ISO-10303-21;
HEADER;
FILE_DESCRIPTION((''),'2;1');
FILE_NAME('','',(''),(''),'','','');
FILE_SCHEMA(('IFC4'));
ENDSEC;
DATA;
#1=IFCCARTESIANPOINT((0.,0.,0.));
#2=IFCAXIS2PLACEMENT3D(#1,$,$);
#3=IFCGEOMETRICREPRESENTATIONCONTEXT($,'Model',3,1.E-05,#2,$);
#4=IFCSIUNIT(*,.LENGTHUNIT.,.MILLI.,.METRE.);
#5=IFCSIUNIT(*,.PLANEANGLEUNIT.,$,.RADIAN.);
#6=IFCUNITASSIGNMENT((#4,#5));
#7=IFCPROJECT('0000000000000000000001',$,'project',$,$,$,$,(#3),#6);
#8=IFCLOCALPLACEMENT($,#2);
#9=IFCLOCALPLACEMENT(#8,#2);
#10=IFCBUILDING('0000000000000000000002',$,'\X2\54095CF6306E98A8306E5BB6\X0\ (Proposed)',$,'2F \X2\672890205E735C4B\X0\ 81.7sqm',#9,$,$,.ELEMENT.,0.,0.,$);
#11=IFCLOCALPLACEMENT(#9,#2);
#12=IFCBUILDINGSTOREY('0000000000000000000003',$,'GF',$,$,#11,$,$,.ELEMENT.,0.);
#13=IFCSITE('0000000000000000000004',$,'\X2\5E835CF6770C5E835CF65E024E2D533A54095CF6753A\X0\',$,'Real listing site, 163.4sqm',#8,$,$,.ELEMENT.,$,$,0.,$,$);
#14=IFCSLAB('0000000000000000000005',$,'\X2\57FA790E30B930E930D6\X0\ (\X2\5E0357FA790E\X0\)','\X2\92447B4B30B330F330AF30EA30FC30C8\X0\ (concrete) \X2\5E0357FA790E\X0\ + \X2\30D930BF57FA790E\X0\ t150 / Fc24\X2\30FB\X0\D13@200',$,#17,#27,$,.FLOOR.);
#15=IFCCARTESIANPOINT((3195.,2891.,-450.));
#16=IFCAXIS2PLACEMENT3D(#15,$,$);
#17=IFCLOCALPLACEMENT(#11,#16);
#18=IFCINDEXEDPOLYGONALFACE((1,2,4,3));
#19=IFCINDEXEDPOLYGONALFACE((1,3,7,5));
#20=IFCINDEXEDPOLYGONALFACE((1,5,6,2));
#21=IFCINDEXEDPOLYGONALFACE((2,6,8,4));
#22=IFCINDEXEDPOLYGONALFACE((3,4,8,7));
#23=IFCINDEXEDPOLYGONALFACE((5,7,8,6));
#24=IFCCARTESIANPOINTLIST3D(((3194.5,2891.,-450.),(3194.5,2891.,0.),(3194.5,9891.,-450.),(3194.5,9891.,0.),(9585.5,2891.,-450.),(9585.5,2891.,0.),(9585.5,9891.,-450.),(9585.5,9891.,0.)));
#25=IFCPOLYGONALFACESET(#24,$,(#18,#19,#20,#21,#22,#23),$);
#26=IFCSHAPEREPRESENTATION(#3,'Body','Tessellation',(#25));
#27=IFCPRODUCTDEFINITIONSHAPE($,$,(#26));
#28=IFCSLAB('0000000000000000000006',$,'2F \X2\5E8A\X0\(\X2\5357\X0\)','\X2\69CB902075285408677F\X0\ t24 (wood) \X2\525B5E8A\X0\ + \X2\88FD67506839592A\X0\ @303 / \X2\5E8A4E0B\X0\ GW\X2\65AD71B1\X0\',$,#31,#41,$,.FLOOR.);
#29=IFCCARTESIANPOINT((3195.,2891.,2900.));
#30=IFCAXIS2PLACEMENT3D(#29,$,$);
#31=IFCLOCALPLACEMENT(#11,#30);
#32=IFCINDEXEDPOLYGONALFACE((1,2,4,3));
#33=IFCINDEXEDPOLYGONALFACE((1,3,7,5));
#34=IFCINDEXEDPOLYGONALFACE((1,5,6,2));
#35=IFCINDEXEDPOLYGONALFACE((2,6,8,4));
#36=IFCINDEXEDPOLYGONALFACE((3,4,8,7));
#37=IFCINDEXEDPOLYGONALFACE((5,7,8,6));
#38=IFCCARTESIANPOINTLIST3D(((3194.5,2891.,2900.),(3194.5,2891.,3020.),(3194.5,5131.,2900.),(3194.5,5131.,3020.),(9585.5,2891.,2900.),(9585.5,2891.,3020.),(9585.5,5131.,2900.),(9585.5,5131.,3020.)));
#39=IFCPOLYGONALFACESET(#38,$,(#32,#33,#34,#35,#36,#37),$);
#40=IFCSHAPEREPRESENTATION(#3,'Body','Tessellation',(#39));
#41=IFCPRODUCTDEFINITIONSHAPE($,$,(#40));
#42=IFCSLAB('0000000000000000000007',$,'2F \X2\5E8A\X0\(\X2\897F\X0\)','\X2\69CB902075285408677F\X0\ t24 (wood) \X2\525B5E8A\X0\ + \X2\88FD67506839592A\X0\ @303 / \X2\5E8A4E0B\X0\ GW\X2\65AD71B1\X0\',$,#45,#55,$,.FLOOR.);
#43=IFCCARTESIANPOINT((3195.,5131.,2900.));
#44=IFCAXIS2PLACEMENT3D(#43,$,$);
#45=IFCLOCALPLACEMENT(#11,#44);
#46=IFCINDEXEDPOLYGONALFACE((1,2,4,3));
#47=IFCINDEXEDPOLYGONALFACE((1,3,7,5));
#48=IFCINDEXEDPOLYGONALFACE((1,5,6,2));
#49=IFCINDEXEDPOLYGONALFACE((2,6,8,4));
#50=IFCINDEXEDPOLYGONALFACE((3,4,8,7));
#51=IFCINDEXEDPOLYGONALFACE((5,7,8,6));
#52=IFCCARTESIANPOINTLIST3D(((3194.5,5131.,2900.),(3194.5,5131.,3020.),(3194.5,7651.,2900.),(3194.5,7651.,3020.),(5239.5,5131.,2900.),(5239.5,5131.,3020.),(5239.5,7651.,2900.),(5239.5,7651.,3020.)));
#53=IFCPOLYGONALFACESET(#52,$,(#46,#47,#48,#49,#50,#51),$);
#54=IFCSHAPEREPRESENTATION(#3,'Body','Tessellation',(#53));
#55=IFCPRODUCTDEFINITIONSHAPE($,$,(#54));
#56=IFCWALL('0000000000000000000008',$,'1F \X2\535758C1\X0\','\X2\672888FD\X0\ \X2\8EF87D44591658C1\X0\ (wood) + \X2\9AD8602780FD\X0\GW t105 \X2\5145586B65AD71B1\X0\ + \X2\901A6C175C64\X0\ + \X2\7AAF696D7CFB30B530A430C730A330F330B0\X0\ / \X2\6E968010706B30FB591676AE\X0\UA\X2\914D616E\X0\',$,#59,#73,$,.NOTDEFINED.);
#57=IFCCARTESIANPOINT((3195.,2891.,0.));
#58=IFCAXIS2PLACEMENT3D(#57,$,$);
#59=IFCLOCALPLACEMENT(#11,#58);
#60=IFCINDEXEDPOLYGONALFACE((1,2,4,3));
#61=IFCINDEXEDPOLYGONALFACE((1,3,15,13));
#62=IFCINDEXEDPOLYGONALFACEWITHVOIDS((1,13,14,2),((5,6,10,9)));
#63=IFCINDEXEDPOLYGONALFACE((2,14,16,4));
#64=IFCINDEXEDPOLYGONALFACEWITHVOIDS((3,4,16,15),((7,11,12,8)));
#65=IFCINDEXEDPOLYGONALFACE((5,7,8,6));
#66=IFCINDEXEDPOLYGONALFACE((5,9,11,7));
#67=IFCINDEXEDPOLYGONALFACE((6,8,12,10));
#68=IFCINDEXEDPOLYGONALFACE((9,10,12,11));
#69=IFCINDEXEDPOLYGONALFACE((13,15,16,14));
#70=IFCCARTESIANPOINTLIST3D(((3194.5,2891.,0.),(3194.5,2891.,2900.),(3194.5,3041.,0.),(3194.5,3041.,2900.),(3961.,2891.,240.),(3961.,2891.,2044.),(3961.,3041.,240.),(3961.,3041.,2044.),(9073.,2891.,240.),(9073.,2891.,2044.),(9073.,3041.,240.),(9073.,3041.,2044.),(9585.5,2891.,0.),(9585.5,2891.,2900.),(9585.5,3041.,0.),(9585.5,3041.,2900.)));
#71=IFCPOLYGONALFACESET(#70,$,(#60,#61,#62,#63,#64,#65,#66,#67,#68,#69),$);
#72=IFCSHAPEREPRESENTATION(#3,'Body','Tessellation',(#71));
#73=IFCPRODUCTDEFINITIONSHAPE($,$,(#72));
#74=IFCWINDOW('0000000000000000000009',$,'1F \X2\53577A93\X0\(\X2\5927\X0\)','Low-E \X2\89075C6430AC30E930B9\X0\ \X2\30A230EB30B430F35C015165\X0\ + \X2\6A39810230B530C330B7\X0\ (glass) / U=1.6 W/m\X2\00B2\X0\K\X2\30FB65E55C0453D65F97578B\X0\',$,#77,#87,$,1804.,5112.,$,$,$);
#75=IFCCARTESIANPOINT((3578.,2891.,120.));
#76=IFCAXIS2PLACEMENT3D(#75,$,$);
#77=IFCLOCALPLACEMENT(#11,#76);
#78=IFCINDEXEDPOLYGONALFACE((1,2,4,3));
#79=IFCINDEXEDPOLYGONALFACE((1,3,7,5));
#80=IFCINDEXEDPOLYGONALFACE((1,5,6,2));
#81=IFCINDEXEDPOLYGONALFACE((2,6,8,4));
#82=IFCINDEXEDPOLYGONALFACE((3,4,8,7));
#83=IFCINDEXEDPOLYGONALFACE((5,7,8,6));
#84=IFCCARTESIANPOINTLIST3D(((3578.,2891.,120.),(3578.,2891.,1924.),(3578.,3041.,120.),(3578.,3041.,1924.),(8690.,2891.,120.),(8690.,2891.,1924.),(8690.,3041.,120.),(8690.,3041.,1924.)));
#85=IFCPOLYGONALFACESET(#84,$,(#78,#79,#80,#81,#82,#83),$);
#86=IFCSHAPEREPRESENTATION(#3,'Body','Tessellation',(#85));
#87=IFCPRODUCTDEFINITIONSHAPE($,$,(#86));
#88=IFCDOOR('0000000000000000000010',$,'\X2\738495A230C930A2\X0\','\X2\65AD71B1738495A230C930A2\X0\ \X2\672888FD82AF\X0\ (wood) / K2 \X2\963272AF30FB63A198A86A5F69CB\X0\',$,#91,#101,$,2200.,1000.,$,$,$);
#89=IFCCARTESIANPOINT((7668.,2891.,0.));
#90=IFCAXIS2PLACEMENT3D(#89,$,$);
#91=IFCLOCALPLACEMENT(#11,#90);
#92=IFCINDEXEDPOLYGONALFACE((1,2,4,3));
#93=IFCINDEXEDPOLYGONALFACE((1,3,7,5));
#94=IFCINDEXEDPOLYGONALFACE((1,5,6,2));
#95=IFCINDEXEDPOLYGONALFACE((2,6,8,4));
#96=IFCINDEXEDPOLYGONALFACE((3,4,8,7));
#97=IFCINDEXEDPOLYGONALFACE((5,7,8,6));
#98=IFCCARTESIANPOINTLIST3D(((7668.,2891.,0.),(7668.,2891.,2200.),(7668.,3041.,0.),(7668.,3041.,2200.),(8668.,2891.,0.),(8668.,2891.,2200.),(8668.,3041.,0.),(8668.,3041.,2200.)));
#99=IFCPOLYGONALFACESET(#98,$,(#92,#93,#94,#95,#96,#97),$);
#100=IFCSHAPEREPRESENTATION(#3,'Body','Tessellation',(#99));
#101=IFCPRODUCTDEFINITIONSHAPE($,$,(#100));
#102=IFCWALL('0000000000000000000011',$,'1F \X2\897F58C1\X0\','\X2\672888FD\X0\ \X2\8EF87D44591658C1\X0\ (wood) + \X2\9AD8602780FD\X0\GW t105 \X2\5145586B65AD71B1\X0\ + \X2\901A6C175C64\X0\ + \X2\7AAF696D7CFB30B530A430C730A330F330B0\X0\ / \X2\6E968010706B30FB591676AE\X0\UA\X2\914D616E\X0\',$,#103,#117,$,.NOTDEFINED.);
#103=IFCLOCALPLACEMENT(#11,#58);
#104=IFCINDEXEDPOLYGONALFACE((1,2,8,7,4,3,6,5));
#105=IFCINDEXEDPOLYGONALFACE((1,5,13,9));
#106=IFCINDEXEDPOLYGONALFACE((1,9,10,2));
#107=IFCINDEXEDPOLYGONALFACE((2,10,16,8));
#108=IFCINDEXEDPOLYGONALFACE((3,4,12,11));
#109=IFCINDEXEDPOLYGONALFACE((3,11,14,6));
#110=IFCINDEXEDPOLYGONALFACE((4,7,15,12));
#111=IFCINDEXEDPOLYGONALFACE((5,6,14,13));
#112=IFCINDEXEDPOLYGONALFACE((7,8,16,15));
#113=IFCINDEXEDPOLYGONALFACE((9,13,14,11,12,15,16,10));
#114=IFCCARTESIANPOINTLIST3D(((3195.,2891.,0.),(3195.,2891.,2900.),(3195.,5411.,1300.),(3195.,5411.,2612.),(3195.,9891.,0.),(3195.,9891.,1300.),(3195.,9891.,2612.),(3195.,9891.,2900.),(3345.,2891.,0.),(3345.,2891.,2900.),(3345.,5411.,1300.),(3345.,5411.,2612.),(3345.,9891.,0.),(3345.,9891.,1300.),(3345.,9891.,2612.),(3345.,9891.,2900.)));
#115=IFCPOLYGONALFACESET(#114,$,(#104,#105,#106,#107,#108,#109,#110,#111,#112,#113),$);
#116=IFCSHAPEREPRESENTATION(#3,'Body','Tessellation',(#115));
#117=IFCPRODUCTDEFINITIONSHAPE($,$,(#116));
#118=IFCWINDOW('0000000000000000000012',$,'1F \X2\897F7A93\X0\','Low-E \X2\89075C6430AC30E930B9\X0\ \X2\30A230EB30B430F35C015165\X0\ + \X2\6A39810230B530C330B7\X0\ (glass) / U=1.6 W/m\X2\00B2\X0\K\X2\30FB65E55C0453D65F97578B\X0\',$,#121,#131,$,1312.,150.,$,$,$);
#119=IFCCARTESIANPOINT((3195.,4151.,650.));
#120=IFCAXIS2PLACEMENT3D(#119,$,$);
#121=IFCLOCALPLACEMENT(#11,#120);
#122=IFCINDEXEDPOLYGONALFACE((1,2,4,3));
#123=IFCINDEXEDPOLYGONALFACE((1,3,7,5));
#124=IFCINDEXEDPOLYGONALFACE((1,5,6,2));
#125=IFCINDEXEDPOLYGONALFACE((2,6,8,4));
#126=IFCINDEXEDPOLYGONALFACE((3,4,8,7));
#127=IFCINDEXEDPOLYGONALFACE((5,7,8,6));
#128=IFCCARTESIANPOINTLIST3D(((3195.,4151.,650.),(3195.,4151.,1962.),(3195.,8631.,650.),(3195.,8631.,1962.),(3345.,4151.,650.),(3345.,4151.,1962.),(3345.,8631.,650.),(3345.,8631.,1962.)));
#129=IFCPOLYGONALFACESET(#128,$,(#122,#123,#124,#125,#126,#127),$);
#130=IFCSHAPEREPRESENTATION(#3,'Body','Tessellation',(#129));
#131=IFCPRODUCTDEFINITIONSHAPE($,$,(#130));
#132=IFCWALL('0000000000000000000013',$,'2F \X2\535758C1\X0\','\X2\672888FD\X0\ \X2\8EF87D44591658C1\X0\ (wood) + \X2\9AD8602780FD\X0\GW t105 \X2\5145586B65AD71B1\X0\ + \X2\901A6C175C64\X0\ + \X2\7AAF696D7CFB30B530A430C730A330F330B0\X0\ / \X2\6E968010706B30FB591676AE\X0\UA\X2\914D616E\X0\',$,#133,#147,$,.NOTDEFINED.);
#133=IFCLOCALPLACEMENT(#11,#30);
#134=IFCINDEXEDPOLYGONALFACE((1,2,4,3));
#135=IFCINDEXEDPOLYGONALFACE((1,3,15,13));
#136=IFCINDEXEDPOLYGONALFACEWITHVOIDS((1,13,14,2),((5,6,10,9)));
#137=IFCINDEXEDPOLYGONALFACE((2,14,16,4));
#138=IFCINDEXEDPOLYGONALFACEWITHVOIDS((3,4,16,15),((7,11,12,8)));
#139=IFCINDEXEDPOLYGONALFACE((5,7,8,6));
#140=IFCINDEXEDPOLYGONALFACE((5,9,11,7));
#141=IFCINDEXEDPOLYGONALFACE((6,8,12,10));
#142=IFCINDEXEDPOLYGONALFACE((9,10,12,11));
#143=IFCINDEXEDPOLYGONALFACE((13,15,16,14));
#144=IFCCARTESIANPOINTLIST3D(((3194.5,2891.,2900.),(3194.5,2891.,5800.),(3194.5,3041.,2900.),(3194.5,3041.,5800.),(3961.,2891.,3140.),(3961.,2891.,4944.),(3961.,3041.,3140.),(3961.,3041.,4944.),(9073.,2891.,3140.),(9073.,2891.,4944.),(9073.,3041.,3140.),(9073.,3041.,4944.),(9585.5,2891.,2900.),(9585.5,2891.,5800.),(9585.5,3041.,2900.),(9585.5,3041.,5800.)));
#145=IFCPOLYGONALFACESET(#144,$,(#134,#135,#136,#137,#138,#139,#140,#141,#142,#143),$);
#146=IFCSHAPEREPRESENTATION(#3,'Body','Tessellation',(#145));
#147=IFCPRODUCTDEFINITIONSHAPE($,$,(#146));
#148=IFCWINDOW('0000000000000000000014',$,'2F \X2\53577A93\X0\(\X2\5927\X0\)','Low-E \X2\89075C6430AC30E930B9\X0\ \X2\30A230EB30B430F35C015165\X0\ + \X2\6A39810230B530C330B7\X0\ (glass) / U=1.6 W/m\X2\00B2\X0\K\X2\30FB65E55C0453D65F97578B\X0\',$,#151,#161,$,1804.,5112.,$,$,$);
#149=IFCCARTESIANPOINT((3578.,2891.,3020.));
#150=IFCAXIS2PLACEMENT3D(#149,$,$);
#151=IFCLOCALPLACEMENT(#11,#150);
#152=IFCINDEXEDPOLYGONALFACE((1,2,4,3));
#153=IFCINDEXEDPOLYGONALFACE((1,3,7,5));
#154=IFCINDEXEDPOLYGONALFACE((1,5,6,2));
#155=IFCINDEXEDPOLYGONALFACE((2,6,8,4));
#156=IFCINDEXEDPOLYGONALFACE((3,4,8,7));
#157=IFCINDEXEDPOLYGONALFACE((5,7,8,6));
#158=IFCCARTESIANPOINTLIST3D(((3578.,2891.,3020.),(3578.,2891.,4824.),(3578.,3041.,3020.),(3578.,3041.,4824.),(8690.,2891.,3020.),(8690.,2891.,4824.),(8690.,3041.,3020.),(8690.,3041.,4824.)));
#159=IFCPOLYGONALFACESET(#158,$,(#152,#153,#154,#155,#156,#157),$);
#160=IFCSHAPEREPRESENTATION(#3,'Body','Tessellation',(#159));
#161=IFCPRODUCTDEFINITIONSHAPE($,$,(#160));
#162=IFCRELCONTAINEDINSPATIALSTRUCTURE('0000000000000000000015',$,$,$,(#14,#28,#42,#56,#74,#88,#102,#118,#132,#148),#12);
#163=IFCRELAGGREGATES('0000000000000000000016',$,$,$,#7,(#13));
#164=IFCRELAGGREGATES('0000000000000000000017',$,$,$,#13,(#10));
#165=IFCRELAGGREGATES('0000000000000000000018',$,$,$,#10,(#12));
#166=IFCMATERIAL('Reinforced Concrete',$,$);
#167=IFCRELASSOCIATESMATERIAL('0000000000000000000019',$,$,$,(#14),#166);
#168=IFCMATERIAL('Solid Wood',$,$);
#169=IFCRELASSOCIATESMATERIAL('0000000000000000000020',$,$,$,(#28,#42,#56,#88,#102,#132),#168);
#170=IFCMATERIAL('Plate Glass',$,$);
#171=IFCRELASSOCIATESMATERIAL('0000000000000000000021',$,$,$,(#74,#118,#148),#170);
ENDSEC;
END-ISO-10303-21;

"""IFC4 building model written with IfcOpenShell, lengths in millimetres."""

from ifc_helpers import new_model, si_unit, frame, frame_2d, origin, place, context, project, spatial, rectangle, extrude, material, element, fill, save


model = new_model("IFC4")

# Units and contexts
model_context = context("Model", 3, precision=1e-05, world=origin())
ifc_project = project(units=[si_unit("LENGTHUNIT", "METRE", prefix="MILLI"), si_unit("PLANEANGLEUNIT", "RADIAN")], contexts=[model_context])

# Site, building, storey
site_placement = place(None, origin())
site = spatial("IfcSite", under=ifc_project, at=site_placement, Name="広島県広島市中区吉島町", ObjectType="Real listing site, 163.4sqm", CompositionType="ELEMENT", RefElevation=0.0)
building_placement = place(site_placement, origin())
building = spatial("IfcBuilding", under=site, at=building_placement, Name="吉島の風の家 (Proposed)", ObjectType="2F 木造平屋 81.7sqm", CompositionType="ELEMENT", ElevationOfRefHeight=0.0, ElevationOfTerrain=0.0)
storey_placement = place(building_placement, origin())
storey = spatial("IfcBuildingStorey", under=building, at=storey_placement, Name="GF", CompositionType="ELEMENT", Elevation=0.0)

# Slabs
ifc_material_1 = material(Name="Reinforced Concrete")
slab_1_placement = place(storey_placement, frame((3195.0, 2891.0, -450.0)))
element("IfcSlab", 1, at=slab_1_placement, inside=storey, material=ifc_material_1, Name="基礎スラブ (布基礎)", Description="鉄筋コンクリート (concrete) 布基礎 + ベタ基礎 t150 / Fc24・D13@200", PredefinedType="FLOOR", context=model_context, shape_type="SweptSolid", body=[
    extrude(rectangle(XDim=6391.0, YDim=7000.0, at=frame_2d((3195.0, 3500.0))), frame((3195.0, 2891.0, -450.0)), (0.0, 0.0, 1.0), 450.0),
])
ifc_material_2 = material(Name="Solid Wood")
slab_2_placement = place(storey_placement, frame((3195.0, 2891.0, 2900.0)))
element("IfcSlab", 2, at=slab_2_placement, inside=storey, material=ifc_material_2, Name="2F 床(南)", Description="構造用合板 t24 (wood) 剛床 + 製材根太 @303 / 床下 GW断熱", PredefinedType="FLOOR", context=model_context, shape_type="SweptSolid", body=[
    extrude(rectangle(XDim=6391.0, YDim=2240.0, at=frame_2d((3195.0, 1120.0))), frame((3195.0, 2891.0, 2900.0)), (0.0, 0.0, 1.0), 120.0),
])
slab_3_placement = place(storey_placement, frame((3195.0, 5131.0, 2900.0)))
element("IfcSlab", 3, at=slab_3_placement, inside=storey, material=ifc_material_2, Name="2F 床(西)", Description="構造用合板 t24 (wood) 剛床 + 製材根太 @303 / 床下 GW断熱", PredefinedType="FLOOR", context=model_context, shape_type="SweptSolid", body=[
    extrude(rectangle(XDim=2045.0, YDim=2520.0, at=frame_2d((1022.0, 1260.0))), frame((3195.0, 5131.0, 2900.0)), (0.0, 0.0, 1.0), 120.0),
])

# Wall, openings, window, door
wall_1_placement = place(storey_placement, frame((3195.0, 2891.0, 0.0)))
wall_1 = element("IfcWall", 4, at=wall_1_placement, inside=storey, material=ifc_material_2, Name="1F 南壁", Description="木製 軸組外壁 (wood) + 高性能GW t105 充填断熱 + 通気層 + 窯業系サイディング / 準耐火・外皮UA配慮", PredefinedType="NOTDEFINED", context=model_context, shape_type="SweptSolid", body=[
    extrude(rectangle(XDim=6391.0, YDim=150.0, at=frame_2d((3195.0, 75.0))), frame((3195.0, 2891.0, 0.0)), (0.0, 0.0, 1.0), 2900.0),
])
opening_1_placement = place(storey_placement, frame((3578.0, 2891.0, 120.0)))
opening_1 = element("IfcOpeningElement", 5, at=opening_1_placement, cuts=wall_1, PredefinedType="NOTDEFINED", context=model_context, shape_type="SweptSolid", body=[
    extrude(rectangle(XDim=5112.0, YDim=150.0, at=frame_2d((2556.0, 75.0))), frame((3578.0, 2891.0, 120.0)), (0.0, 0.0, 1.0), 1804.0),
])
opening_2_placement = place(storey_placement, frame((7668.0, 2891.0, 0.0)))
opening_2 = element("IfcOpeningElement", 6, at=opening_2_placement, cuts=wall_1, PredefinedType="NOTDEFINED", context=model_context, shape_type="SweptSolid", body=[
    extrude(rectangle(XDim=1000.0, YDim=150.0, at=frame_2d((500.0, 75.0))), frame((7668.0, 2891.0, 0.0)), (0.0, 0.0, 1.0), 2200.0),
])
ifc_material_3 = material(Name="Plate Glass")
window_1_placement = place(storey_placement, frame((3578.0, 2891.0, 120.0)))
window_1 = element("IfcWindow", 7, at=window_1_placement, inside=storey, material=ifc_material_3, Name="1F 南窓(大)", Description="Low-E 複層ガラス アルゴン封入 + 樹脂サッシ (glass) / U=1.6 W/m²K・日射取得型", OverallHeight=1804.0, OverallWidth=5112.0, context=model_context, shape_type="SweptSolid", body=[
    extrude(rectangle(XDim=5112.0, YDim=150.0, at=frame_2d((2556.0, 75.0))), frame((3578.0, 2891.0, 120.0)), (0.0, 0.0, 1.0), 1804.0),
])
fill(opening_1, window_1)
door_placement = place(storey_placement, frame((7668.0, 2891.0, 0.0)))
door = element("IfcDoor", 8, at=door_placement, inside=storey, material=ifc_material_2, Name="玄関ドア", Description="断熱玄関ドア 木製芯 (wood) / K2 防犯・採風機構", OverallHeight=2200.0, OverallWidth=1000.0, context=model_context, shape_type="SweptSolid", body=[
    extrude(rectangle(XDim=1000.0, YDim=150.0, at=frame_2d((500.0, 75.0))), frame((7668.0, 2891.0, 0.0)), (0.0, 0.0, 1.0), 2200.0),
])
fill(opening_2, door)

# Walls, openings, windows
wall_2_placement = place(storey_placement, frame((3195.0, 2891.0, 0.0)))
wall_2 = element("IfcWall", 9, at=wall_2_placement, inside=storey, material=ifc_material_2, Name="1F 西壁", Description="木製 軸組外壁 (wood) + 高性能GW t105 充填断熱 + 通気層 + 窯業系サイディング / 準耐火・外皮UA配慮", PredefinedType="NOTDEFINED", context=model_context, shape_type="SweptSolid", body=[
    extrude(rectangle(XDim=150.0, YDim=7000.0, at=frame_2d((75.0, 3500.0))), frame((3195.0, 2891.0, 0.0)), (0.0, 0.0, 1.0), 2900.0),
])
opening_3_placement = place(storey_placement, frame((3195.0, 4151.0, 650.0)))
opening_3 = element("IfcOpeningElement", 10, at=opening_3_placement, cuts=wall_2, PredefinedType="NOTDEFINED", context=model_context, shape_type="SweptSolid", body=[
    extrude(rectangle(XDim=150.0, YDim=4480.0, at=frame_2d((75.0, 2240.0))), frame((3195.0, 4151.0, 650.0)), (0.0, 0.0, 1.0), 1312.0),
])
window_2_placement = place(storey_placement, frame((3195.0, 4151.0, 650.0)))
window_2 = element("IfcWindow", 11, at=window_2_placement, inside=storey, material=ifc_material_3, Name="1F 西窓", Description="Low-E 複層ガラス アルゴン封入 + 樹脂サッシ (glass) / U=1.6 W/m²K・日射取得型", OverallHeight=1312.0, OverallWidth=150.0, context=model_context, shape_type="SweptSolid", body=[
    extrude(rectangle(XDim=150.0, YDim=4480.0, at=frame_2d((75.0, 2240.0))), frame((3195.0, 4151.0, 650.0)), (0.0, 0.0, 1.0), 1312.0),
])
fill(opening_3, window_2)
wall_3_placement = place(storey_placement, frame((3195.0, 2891.0, 2900.0)))
wall_3 = element("IfcWall", 12, at=wall_3_placement, inside=storey, material=ifc_material_2, Name="2F 南壁", Description="木製 軸組外壁 (wood) + 高性能GW t105 充填断熱 + 通気層 + 窯業系サイディング / 準耐火・外皮UA配慮", PredefinedType="NOTDEFINED", context=model_context, shape_type="SweptSolid", body=[
    extrude(rectangle(XDim=6391.0, YDim=150.0, at=frame_2d((3195.0, 75.0))), frame((3195.0, 2891.0, 2900.0)), (0.0, 0.0, 1.0), 2900.0),
])
opening_4_placement = place(storey_placement, frame((3578.0, 2891.0, 3020.0)))
opening_4 = element("IfcOpeningElement", 13, at=opening_4_placement, cuts=wall_3, PredefinedType="NOTDEFINED", context=model_context, shape_type="SweptSolid", body=[
    extrude(rectangle(XDim=5112.0, YDim=150.0, at=frame_2d((2556.0, 75.0))), frame((3578.0, 2891.0, 3020.0)), (0.0, 0.0, 1.0), 1804.0),
])
window_3_placement = place(storey_placement, frame((3578.0, 2891.0, 3020.0)))
window_3 = element("IfcWindow", 14, at=window_3_placement, inside=storey, material=ifc_material_3, Name="2F 南窓(大)", Description="Low-E 複層ガラス アルゴン封入 + 樹脂サッシ (glass) / U=1.6 W/m²K・日射取得型", OverallHeight=1804.0, OverallWidth=5112.0, context=model_context, shape_type="SweptSolid", body=[
    extrude(rectangle(XDim=5112.0, YDim=150.0, at=frame_2d((2556.0, 75.0))), frame((3578.0, 2891.0, 3020.0)), (0.0, 0.0, 1.0), 1804.0),
])
fill(opening_4, window_3)

save(model, "model.ifc")
